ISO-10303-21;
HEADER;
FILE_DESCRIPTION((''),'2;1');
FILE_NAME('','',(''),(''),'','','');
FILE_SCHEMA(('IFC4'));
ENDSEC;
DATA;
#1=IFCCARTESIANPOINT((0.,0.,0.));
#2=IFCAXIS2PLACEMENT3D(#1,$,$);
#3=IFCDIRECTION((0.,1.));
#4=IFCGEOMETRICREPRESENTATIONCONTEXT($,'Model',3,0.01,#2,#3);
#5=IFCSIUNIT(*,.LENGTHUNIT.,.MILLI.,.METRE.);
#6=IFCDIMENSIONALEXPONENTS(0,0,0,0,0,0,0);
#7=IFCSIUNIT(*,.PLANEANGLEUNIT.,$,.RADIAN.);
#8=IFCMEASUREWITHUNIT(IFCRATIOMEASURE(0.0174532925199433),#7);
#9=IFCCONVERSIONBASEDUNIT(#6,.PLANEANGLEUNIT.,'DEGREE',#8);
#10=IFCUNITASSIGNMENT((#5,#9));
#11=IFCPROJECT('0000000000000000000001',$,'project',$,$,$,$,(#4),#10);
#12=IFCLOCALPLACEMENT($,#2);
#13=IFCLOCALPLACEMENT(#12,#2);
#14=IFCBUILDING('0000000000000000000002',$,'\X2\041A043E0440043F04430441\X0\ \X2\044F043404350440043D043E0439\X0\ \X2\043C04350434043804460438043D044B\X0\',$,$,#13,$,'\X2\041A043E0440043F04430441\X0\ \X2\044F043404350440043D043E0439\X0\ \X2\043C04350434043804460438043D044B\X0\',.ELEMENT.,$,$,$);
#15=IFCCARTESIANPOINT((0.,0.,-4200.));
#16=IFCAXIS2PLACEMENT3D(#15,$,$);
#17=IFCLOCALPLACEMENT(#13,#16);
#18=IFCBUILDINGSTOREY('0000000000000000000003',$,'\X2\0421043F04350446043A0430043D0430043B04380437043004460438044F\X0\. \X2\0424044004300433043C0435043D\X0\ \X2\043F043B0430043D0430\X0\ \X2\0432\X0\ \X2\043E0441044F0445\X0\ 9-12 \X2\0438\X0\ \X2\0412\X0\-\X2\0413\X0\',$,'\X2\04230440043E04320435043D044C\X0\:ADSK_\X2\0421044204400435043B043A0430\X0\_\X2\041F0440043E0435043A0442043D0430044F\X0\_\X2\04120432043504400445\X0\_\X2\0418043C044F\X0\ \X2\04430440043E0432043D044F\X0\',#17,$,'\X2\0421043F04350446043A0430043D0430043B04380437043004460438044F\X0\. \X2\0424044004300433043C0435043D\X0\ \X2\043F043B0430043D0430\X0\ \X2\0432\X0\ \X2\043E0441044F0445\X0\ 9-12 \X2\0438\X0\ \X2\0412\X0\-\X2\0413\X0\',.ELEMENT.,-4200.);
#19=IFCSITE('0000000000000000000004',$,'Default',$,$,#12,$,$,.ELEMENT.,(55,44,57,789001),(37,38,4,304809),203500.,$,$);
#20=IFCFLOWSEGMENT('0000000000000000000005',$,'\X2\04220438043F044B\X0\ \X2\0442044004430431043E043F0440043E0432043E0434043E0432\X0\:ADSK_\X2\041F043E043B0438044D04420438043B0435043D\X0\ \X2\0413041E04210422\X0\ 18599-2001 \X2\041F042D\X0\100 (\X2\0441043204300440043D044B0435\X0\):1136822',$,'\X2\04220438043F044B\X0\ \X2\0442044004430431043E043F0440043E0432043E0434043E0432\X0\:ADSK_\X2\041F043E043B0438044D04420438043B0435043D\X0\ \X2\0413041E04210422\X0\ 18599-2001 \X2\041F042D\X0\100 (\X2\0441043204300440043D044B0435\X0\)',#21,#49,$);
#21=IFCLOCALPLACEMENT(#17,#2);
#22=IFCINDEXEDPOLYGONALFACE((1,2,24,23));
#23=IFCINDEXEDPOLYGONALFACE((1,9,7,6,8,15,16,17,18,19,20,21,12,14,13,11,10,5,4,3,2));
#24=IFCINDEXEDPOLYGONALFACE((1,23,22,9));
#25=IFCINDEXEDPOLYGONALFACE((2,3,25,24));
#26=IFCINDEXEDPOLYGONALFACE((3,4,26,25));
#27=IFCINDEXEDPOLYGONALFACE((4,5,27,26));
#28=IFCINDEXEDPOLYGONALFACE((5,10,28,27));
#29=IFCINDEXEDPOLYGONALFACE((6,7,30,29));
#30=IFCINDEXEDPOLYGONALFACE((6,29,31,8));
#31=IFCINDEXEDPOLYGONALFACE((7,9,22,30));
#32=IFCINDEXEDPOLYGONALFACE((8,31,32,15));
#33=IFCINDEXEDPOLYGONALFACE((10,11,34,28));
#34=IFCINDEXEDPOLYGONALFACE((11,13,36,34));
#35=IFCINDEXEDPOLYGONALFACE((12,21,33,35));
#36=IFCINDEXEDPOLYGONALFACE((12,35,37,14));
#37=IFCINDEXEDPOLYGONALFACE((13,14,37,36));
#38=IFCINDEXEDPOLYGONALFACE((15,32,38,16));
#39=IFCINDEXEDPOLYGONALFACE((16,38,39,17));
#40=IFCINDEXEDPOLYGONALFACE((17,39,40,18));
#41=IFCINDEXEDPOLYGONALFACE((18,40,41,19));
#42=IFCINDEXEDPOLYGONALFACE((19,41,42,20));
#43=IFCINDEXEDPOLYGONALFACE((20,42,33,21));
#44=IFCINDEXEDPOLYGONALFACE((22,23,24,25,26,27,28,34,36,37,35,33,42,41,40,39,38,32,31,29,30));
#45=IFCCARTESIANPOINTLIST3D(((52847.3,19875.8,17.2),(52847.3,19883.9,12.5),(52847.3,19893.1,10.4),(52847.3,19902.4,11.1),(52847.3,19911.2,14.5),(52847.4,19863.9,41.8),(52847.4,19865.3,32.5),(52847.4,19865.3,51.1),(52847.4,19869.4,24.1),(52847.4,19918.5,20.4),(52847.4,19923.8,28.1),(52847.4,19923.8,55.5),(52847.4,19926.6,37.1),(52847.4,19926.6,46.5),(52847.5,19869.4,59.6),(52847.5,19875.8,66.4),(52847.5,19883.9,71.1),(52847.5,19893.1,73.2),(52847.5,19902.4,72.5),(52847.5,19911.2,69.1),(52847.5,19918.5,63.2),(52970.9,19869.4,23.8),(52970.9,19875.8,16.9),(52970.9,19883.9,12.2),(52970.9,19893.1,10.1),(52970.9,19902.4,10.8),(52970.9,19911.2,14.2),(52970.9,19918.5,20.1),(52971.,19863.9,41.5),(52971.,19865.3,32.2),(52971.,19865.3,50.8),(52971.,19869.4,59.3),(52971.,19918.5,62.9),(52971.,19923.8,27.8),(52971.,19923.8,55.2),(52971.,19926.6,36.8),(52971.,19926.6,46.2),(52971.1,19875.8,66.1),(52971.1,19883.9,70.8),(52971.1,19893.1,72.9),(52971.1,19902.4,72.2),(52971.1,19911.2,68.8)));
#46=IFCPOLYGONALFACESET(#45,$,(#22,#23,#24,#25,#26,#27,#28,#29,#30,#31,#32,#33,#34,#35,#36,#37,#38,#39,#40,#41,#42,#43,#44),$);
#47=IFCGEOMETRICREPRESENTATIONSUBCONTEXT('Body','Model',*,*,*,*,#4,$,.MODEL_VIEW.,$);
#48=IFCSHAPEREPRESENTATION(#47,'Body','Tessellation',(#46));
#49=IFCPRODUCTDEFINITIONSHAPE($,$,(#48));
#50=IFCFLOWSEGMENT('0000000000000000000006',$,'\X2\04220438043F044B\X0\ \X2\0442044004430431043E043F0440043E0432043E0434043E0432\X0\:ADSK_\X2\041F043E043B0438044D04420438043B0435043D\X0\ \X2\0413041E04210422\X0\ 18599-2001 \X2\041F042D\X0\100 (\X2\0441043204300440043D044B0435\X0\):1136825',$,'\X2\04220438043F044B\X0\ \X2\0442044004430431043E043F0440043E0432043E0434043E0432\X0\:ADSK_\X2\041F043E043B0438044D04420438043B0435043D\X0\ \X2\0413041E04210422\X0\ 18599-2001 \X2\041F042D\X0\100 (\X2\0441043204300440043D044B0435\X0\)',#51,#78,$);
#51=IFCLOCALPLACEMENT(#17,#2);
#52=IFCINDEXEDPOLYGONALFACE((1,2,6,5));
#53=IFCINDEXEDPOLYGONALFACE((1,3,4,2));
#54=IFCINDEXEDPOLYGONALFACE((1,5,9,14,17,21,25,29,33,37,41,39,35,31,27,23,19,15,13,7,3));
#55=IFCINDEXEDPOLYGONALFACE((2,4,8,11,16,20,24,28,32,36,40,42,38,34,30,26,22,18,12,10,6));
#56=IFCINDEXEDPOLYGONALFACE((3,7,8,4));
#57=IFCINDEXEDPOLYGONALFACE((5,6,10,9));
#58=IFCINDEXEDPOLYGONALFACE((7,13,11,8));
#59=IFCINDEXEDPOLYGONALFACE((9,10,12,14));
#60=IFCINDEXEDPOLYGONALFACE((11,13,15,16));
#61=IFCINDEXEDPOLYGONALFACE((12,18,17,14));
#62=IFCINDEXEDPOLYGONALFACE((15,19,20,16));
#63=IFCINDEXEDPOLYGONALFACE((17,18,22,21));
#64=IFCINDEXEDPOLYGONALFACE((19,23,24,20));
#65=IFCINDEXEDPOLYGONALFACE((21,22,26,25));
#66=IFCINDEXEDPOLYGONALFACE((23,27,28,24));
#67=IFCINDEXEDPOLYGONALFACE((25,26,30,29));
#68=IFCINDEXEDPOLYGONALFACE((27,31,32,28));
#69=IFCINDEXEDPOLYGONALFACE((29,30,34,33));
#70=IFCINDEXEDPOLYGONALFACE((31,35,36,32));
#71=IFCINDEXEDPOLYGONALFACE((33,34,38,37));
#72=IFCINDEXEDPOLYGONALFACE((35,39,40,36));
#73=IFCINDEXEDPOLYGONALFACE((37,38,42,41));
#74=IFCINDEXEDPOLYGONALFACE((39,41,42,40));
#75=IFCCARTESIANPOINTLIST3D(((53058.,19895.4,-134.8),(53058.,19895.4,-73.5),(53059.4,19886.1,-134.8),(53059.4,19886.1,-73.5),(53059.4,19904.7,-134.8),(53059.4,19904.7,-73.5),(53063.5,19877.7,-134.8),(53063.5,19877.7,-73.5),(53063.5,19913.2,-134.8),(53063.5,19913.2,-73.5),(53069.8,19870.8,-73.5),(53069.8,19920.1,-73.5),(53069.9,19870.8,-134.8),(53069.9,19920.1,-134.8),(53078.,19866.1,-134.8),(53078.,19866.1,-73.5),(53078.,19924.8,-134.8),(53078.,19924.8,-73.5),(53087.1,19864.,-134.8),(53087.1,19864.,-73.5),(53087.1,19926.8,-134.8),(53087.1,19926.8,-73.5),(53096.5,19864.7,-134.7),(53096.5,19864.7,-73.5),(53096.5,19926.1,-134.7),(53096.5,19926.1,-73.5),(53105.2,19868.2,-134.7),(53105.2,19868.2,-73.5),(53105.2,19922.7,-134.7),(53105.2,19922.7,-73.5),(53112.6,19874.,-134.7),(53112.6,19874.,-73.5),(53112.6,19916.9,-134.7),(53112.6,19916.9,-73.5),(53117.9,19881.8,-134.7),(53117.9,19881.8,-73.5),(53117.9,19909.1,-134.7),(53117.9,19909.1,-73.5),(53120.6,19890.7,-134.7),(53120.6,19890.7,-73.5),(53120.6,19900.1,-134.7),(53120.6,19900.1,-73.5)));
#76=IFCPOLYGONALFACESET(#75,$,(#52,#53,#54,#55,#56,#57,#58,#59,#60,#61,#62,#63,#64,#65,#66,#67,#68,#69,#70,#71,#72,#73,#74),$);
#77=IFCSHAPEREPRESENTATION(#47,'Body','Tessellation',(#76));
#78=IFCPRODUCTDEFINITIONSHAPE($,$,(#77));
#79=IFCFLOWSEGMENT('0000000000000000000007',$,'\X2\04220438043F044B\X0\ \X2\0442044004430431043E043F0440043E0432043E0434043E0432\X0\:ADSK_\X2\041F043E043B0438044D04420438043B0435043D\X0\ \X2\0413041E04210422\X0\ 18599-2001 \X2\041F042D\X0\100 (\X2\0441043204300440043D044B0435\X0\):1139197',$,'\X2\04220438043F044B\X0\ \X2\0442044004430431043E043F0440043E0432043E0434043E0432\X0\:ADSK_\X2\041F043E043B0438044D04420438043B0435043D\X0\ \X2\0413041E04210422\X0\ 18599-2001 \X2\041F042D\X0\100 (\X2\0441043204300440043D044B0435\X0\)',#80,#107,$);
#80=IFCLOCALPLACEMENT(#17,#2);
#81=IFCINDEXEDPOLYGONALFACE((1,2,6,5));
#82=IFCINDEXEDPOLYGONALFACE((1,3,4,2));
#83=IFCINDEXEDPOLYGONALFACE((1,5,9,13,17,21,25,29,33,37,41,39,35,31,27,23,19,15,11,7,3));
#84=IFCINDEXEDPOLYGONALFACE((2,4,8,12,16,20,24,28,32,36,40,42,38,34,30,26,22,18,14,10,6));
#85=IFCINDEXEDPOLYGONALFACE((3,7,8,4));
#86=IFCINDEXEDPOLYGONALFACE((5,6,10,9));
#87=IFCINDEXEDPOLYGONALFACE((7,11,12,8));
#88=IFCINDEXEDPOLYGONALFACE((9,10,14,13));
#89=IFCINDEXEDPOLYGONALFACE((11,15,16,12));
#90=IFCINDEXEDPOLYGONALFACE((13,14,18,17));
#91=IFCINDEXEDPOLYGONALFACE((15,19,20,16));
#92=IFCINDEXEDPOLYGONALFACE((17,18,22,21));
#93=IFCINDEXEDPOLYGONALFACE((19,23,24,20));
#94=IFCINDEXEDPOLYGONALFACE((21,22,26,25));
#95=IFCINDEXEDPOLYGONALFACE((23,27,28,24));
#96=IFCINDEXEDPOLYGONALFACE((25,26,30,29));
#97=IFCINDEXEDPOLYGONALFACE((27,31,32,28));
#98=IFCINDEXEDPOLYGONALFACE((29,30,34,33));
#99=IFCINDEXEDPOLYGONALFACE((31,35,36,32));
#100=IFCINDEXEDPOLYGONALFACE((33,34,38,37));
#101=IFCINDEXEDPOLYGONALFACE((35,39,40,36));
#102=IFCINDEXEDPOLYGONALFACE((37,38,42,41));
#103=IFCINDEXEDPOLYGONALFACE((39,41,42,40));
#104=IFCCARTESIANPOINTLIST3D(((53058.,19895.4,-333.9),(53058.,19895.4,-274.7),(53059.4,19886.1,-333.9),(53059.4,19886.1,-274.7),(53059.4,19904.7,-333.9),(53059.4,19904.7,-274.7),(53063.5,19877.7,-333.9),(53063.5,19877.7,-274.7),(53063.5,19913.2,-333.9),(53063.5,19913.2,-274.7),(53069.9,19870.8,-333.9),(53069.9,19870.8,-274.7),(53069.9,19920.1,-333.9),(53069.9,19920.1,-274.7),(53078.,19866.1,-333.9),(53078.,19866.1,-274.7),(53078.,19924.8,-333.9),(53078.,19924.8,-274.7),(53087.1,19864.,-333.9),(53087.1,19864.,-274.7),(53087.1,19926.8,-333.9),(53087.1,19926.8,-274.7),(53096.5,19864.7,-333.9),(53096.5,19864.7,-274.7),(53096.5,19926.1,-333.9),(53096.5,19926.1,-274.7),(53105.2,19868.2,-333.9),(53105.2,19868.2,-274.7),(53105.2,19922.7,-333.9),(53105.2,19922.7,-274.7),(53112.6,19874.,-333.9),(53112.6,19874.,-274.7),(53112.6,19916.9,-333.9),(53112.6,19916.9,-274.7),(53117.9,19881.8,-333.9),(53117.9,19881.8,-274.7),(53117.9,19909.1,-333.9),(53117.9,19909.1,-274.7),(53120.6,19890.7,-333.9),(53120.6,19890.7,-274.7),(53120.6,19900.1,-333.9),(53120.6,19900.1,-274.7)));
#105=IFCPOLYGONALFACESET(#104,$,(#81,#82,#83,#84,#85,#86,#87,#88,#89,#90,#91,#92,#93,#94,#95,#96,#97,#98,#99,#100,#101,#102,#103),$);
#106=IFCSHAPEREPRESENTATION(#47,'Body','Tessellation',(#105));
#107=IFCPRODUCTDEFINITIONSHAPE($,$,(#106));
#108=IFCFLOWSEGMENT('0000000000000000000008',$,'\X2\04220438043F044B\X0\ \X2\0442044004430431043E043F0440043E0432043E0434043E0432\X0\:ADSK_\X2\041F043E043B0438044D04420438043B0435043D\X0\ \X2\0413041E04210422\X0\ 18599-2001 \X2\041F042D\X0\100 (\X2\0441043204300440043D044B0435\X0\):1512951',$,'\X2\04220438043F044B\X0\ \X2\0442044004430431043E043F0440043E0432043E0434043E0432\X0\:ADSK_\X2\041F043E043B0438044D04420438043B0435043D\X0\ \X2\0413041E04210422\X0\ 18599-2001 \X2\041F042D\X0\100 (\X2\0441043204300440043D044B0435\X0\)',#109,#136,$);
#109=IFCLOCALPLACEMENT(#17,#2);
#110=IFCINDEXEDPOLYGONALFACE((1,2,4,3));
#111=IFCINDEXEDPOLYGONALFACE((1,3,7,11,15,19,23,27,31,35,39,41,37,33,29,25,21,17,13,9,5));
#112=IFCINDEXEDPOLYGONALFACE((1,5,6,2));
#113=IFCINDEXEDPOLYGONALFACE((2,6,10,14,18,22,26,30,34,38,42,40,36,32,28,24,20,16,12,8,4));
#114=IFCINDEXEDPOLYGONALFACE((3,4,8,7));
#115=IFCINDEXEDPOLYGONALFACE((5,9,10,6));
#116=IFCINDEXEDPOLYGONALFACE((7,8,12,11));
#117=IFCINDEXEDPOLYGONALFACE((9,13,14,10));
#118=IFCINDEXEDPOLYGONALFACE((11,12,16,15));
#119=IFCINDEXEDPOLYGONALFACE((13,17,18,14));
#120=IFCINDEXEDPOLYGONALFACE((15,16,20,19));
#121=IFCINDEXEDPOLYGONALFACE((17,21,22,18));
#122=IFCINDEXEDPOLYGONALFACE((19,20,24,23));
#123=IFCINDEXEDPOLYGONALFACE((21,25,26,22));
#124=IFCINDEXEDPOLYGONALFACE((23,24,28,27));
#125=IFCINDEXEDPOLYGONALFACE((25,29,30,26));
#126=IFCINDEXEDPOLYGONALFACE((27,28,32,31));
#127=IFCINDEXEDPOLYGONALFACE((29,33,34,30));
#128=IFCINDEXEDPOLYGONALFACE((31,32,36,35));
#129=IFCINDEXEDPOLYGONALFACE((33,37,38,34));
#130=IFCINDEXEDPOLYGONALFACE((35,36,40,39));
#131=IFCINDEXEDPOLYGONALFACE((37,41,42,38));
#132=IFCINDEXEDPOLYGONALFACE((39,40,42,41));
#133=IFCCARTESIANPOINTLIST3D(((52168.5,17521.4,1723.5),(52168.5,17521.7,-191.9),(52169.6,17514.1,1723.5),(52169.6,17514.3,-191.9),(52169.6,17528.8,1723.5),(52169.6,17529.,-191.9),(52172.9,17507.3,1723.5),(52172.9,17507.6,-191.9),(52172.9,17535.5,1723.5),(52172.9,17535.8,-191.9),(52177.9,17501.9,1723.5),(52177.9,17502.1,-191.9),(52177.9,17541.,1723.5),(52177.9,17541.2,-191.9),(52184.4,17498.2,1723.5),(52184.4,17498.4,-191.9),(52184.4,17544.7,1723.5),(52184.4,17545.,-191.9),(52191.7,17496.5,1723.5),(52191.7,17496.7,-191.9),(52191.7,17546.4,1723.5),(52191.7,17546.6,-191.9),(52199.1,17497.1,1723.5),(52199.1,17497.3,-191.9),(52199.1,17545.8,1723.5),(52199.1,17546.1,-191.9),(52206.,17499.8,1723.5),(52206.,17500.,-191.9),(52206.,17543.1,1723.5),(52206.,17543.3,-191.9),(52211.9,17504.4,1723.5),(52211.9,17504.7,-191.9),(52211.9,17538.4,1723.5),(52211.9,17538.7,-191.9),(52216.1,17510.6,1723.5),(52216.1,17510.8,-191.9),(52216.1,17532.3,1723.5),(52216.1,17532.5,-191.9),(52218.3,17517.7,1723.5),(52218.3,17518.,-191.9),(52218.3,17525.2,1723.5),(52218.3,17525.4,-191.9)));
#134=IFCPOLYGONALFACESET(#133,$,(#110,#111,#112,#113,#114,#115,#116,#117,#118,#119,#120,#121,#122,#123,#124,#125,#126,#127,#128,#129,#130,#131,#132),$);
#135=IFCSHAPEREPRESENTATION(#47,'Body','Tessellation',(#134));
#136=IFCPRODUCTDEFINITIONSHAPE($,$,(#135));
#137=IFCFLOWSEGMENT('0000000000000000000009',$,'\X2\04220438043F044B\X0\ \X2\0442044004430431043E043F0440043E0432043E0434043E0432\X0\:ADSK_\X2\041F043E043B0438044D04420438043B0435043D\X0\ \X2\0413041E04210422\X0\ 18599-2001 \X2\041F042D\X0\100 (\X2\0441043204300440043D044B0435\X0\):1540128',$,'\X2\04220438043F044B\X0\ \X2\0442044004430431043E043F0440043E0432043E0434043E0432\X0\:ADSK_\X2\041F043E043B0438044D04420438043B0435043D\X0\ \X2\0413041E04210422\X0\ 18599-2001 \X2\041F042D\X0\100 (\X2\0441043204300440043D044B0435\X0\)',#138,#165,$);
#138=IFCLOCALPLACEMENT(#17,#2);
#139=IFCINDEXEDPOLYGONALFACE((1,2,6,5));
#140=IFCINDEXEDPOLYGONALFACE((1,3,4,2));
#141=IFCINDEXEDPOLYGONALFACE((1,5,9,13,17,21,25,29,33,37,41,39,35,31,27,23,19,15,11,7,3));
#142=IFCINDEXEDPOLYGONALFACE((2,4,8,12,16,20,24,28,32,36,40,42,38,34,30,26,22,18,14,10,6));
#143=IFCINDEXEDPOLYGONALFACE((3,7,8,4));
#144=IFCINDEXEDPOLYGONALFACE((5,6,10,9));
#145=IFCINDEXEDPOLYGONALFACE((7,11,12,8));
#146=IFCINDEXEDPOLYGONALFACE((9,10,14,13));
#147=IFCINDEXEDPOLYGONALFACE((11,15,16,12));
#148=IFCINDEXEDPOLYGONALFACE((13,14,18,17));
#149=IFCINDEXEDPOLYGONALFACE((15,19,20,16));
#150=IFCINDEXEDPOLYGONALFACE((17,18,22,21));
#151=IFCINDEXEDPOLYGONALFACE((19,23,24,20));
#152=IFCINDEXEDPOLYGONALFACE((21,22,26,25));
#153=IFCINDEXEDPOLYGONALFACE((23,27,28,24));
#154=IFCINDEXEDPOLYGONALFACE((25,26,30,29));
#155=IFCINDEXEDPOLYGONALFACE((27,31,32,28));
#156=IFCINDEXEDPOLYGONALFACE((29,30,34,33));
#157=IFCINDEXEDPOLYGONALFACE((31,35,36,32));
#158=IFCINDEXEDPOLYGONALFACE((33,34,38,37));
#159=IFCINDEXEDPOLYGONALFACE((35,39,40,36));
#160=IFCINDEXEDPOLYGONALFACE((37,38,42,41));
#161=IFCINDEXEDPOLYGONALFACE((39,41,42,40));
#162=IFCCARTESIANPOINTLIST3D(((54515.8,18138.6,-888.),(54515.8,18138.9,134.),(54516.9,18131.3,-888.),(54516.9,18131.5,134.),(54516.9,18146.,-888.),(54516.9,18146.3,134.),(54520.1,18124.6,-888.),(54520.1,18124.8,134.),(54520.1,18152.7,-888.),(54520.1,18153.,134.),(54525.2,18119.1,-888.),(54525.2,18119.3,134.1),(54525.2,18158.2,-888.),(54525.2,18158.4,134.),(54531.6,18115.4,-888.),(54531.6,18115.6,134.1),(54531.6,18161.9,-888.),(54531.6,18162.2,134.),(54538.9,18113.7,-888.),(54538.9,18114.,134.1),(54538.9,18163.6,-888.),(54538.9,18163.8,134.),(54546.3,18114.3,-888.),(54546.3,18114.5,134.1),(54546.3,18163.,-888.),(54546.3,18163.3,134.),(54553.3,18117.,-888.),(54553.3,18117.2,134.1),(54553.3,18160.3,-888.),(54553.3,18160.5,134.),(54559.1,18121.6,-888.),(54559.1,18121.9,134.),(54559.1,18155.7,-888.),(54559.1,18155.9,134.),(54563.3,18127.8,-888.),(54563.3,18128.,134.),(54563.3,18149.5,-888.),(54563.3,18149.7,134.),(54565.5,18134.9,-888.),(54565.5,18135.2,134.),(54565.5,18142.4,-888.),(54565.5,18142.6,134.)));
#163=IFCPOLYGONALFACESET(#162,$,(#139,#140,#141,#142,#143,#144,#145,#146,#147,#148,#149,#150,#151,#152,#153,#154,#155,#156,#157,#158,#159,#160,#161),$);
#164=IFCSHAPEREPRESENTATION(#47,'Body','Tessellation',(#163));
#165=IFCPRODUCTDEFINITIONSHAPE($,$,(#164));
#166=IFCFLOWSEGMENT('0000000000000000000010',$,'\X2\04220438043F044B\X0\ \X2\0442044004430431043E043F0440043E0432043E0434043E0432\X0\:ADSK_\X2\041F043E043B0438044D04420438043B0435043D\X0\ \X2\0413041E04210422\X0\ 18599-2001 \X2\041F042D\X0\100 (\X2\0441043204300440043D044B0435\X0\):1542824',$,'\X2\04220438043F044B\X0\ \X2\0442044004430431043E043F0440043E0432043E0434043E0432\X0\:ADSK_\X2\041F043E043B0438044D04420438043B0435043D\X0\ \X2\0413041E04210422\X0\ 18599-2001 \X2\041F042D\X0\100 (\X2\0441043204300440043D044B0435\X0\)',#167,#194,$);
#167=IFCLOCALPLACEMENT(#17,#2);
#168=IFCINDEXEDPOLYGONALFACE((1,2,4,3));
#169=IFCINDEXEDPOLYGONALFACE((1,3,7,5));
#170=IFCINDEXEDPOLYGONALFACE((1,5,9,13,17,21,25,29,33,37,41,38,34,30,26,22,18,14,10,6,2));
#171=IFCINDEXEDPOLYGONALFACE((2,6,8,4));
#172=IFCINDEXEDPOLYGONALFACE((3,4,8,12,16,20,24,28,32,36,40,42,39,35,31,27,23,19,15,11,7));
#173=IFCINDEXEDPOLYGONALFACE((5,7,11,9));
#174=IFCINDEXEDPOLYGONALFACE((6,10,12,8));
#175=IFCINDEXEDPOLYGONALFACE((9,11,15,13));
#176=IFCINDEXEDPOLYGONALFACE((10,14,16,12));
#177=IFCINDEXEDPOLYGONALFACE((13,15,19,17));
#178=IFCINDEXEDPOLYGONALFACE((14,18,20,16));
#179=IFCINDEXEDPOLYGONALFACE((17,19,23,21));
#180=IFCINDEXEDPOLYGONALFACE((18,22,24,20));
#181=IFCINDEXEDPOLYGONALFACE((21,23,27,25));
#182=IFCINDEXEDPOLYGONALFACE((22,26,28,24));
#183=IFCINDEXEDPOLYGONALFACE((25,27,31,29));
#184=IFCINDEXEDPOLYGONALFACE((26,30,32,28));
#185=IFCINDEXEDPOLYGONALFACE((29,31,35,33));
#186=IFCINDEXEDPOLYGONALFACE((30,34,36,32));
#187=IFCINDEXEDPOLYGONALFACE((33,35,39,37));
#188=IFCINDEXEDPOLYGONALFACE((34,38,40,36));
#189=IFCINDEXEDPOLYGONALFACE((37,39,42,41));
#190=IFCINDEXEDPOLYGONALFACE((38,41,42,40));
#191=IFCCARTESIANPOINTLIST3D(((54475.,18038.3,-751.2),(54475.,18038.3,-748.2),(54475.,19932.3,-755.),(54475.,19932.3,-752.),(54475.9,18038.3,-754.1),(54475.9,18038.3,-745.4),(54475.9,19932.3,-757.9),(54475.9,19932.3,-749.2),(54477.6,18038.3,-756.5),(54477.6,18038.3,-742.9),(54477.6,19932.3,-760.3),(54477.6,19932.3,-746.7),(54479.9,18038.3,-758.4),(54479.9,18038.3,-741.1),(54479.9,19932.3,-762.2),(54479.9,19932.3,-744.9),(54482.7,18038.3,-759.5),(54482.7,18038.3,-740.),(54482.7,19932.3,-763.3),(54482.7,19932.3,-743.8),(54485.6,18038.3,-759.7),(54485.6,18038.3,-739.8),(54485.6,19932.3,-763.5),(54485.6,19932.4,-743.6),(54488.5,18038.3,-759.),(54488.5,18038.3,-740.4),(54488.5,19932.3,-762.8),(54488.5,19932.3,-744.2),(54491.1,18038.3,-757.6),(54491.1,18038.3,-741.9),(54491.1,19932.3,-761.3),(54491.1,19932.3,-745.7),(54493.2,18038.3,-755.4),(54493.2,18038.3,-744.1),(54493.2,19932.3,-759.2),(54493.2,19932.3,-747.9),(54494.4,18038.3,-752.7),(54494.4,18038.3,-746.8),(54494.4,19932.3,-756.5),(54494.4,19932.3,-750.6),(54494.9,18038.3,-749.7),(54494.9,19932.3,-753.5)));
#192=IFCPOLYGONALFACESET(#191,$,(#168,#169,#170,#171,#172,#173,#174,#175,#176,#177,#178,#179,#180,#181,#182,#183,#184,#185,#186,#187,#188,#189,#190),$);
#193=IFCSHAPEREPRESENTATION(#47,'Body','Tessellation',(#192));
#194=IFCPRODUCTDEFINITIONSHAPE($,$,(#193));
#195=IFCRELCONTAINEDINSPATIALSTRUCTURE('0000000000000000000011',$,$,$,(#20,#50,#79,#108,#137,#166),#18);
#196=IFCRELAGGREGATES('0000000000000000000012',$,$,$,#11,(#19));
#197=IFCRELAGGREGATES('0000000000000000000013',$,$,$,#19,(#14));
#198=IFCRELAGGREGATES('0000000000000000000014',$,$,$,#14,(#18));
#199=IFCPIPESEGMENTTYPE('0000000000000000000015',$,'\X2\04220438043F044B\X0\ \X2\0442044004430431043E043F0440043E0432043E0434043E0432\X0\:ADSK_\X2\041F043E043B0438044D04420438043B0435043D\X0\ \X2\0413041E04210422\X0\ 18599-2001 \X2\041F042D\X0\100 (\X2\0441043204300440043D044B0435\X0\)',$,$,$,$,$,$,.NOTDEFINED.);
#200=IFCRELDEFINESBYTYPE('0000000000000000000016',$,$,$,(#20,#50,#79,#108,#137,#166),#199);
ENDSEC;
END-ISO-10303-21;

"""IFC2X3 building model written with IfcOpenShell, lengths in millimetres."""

from ifc_helpers import new_model, entity, si_unit, converted_unit, direction, frame, origin, origin_2d_with_axis, place, context, subcontext, project, spatial, circle, extrude, type_object, element, save


model = new_model("IFC2X3")

# Units and contexts
model_context = context("Model", 3, precision=0.01, world=origin(), true_north=direction((0.0, 1.0)))
body_context = subcontext(model_context, "Body", "Model", "MODEL_VIEW")
ifc_project = project(units=[si_unit("LENGTHUNIT", "METRE", prefix="MILLI"), converted_unit("PLANEANGLEUNIT", "DEGREE", entity("IfcRatioMeasure", 0.0174532925199433), si_unit("PLANEANGLEUNIT", "RADIAN"), dimensions=[0, 0, 0, 0, 0, 0, 0])], contexts=[model_context])

# Site, building, storey
site_placement = place(None, origin())
site = spatial("IfcSite", under=ifc_project, at=site_placement, Name="Default", CompositionType="ELEMENT", RefLatitude=(55, 44, 57, 789001), RefLongitude=(37, 38, 4, 304809), RefElevation=203500.0)
building_placement = place(site_placement, origin())
building = spatial("IfcBuilding", under=site, at=building_placement, Name="Корпус ядерной медицины", LongName="Корпус ядерной медицины", CompositionType="ELEMENT")
storey_placement = place(building_placement, frame((0.0, 0.0, -4200.0)))
storey = spatial("IfcBuildingStorey", under=building, at=storey_placement, Name="Спецканализация. Фрагмен плана в осях 9-12 и В-Г", ObjectType="Уровень:ADSK_Стрелка_Проектная_Вверх_Имя уровня", LongName="Спецканализация. Фрагмен плана в осях 9-12 и В-Г", CompositionType="ELEMENT", Elevation=-4200.0)

# Flow segments
pipe_segment_type = type_object("IfcPipeSegmentType", Name="Типы трубопроводов:ADSK_Полиэтилен ГОСТ 18599-2001 ПЭ100 (сварные)", PredefinedType="NOTDEFINED")
flow_segment_1_placement = place(storey_placement, frame((52847.3, 19862.3, 8.4)))
element("IfcFlowSegment", 1, at=flow_segment_1_placement, inside=storey, type_object=pipe_segment_type, Name="Типы трубопроводов:ADSK_Полиэтилен ГОСТ 18599-2001 ПЭ100 (сварные):1136822", ObjectType="Типы трубопроводов:ADSK_Полиэтилен ГОСТ 18599-2001 ПЭ100 (сварные)", context=body_context, shape_type="SweptSolid", body=[
    extrude(circle(Radius=31.5, at=origin_2d_with_axis()), frame((0.1, 33.1, 33.4), z_axis=(0.999997, 0.0, -0.002457), x_axis=(0.0, -1.0, 0.0)), (0.0, 0.0, 1.0), 123.6),
])
flow_segment_2_placement = place(storey_placement, frame((53056.4, 19862.3, -134.8)))
element("IfcFlowSegment", 2, at=flow_segment_2_placement, inside=storey, type_object=pipe_segment_type, Name="Типы трубопроводов:ADSK_Полиэтилен ГОСТ 18599-2001 ПЭ100 (сварные):1136825", ObjectType="Типы трубопроводов:ADSK_Полиэтилен ГОСТ 18599-2001 ПЭ100 (сварные)", context=body_context, shape_type="SweptSolid", body=[
    extrude(circle(Radius=31.5, at=origin_2d_with_axis()), frame((33.1, 33.1, 0.0), z_axis=(-0.000005, 0.0, 1.0), x_axis=(-1.0, 0.0, -0.000005)), (0.0, 0.0, 1.0), 61.3),
])
flow_segment_3_placement = place(storey_placement, frame((53056.4, 19862.3, -333.9)))
element("IfcFlowSegment", 3, at=flow_segment_3_placement, inside=storey, type_object=pipe_segment_type, Name="Типы трубопроводов:ADSK_Полиэтилен ГОСТ 18599-2001 ПЭ100 (сварные):1139197", ObjectType="Типы трубопроводов:ADSK_Полиэтилен ГОСТ 18599-2001 ПЭ100 (сварные)", context=body_context, shape_type="SweptSolid", body=[
    extrude(circle(Radius=31.5, at=origin_2d_with_axis()), frame((33.1, 33.1, 0.0), z_axis=(0.000005, 0.0, 1.0), x_axis=(-1.0, 0.0, 0.000005)), (0.0, 0.0, 1.0), 59.1),
])
flow_segment_4_placement = place(storey_placement, frame((52166.9, 17494.8, -191.9)))
element("IfcFlowSegment", 4, at=flow_segment_4_placement, inside=storey, type_object=pipe_segment_type, Name="Типы трубопроводов:ADSK_Полиэтилен ГОСТ 18599-2001 ПЭ100 (сварные):1512951", ObjectType="Типы трубопроводов:ADSK_Полиэтилен ГОСТ 18599-2001 ПЭ100 (сварные)", context=body_context, shape_type="SweptSolid", body=[
    extrude(circle(Radius=25.0, at=origin_2d_with_axis()), frame((26.6, 26.9, 0.0), z_axis=(0.000001, -0.00013, 1.0), x_axis=(-1.0, 0.0, 0.000001)), (0.0, 0.0, 1.0), 1915.3),
])
flow_segment_5_placement = place(storey_placement, frame((54514.2, 18112.0, -888.0)))
element("IfcFlowSegment", 5, at=flow_segment_5_placement, inside=storey, type_object=pipe_segment_type, Name="Типы трубопроводов:ADSK_Полиэтилен ГОСТ 18599-2001 ПЭ100 (сварные):1540128", ObjectType="Типы трубопроводов:ADSK_Полиэтилен ГОСТ 18599-2001 ПЭ100 (сварные)", context=body_context, shape_type="SweptSolid", body=[
    extrude(circle(Radius=25.0, at=origin_2d_with_axis()), frame((26.6, 26.6, 0.0), z_axis=(0.0, 0.000233, 1.0), x_axis=(-1.0, 0.0, 0.0)), (0.0, 0.0, 1.0), 1022.1),
])
flow_segment_6_placement = place(storey_placement, frame((54473.3, 18038.3, -765.1)))
element("IfcFlowSegment", 6, at=flow_segment_6_placement, inside=storey, type_object=pipe_segment_type, Name="Типы трубопроводов:ADSK_Полиэтилен ГОСТ 18599-2001 ПЭ100 (сварные):1542824", ObjectType="Типы трубопроводов:ADSK_Полиэтилен ГОСТ 18599-2001 ПЭ100 (сварные)", context=body_context, shape_type="SweptSolid", body=[
    extrude(circle(Radius=10.0, at=origin_2d_with_axis()), frame((11.6, 0.0, 15.4), z_axis=(0.0, 0.999998, -0.002), x_axis=(1.0, 0.0, 0.0)), (0.0, 0.0, 1.0), 1894.0),
])

save(model, "model.ifc")
